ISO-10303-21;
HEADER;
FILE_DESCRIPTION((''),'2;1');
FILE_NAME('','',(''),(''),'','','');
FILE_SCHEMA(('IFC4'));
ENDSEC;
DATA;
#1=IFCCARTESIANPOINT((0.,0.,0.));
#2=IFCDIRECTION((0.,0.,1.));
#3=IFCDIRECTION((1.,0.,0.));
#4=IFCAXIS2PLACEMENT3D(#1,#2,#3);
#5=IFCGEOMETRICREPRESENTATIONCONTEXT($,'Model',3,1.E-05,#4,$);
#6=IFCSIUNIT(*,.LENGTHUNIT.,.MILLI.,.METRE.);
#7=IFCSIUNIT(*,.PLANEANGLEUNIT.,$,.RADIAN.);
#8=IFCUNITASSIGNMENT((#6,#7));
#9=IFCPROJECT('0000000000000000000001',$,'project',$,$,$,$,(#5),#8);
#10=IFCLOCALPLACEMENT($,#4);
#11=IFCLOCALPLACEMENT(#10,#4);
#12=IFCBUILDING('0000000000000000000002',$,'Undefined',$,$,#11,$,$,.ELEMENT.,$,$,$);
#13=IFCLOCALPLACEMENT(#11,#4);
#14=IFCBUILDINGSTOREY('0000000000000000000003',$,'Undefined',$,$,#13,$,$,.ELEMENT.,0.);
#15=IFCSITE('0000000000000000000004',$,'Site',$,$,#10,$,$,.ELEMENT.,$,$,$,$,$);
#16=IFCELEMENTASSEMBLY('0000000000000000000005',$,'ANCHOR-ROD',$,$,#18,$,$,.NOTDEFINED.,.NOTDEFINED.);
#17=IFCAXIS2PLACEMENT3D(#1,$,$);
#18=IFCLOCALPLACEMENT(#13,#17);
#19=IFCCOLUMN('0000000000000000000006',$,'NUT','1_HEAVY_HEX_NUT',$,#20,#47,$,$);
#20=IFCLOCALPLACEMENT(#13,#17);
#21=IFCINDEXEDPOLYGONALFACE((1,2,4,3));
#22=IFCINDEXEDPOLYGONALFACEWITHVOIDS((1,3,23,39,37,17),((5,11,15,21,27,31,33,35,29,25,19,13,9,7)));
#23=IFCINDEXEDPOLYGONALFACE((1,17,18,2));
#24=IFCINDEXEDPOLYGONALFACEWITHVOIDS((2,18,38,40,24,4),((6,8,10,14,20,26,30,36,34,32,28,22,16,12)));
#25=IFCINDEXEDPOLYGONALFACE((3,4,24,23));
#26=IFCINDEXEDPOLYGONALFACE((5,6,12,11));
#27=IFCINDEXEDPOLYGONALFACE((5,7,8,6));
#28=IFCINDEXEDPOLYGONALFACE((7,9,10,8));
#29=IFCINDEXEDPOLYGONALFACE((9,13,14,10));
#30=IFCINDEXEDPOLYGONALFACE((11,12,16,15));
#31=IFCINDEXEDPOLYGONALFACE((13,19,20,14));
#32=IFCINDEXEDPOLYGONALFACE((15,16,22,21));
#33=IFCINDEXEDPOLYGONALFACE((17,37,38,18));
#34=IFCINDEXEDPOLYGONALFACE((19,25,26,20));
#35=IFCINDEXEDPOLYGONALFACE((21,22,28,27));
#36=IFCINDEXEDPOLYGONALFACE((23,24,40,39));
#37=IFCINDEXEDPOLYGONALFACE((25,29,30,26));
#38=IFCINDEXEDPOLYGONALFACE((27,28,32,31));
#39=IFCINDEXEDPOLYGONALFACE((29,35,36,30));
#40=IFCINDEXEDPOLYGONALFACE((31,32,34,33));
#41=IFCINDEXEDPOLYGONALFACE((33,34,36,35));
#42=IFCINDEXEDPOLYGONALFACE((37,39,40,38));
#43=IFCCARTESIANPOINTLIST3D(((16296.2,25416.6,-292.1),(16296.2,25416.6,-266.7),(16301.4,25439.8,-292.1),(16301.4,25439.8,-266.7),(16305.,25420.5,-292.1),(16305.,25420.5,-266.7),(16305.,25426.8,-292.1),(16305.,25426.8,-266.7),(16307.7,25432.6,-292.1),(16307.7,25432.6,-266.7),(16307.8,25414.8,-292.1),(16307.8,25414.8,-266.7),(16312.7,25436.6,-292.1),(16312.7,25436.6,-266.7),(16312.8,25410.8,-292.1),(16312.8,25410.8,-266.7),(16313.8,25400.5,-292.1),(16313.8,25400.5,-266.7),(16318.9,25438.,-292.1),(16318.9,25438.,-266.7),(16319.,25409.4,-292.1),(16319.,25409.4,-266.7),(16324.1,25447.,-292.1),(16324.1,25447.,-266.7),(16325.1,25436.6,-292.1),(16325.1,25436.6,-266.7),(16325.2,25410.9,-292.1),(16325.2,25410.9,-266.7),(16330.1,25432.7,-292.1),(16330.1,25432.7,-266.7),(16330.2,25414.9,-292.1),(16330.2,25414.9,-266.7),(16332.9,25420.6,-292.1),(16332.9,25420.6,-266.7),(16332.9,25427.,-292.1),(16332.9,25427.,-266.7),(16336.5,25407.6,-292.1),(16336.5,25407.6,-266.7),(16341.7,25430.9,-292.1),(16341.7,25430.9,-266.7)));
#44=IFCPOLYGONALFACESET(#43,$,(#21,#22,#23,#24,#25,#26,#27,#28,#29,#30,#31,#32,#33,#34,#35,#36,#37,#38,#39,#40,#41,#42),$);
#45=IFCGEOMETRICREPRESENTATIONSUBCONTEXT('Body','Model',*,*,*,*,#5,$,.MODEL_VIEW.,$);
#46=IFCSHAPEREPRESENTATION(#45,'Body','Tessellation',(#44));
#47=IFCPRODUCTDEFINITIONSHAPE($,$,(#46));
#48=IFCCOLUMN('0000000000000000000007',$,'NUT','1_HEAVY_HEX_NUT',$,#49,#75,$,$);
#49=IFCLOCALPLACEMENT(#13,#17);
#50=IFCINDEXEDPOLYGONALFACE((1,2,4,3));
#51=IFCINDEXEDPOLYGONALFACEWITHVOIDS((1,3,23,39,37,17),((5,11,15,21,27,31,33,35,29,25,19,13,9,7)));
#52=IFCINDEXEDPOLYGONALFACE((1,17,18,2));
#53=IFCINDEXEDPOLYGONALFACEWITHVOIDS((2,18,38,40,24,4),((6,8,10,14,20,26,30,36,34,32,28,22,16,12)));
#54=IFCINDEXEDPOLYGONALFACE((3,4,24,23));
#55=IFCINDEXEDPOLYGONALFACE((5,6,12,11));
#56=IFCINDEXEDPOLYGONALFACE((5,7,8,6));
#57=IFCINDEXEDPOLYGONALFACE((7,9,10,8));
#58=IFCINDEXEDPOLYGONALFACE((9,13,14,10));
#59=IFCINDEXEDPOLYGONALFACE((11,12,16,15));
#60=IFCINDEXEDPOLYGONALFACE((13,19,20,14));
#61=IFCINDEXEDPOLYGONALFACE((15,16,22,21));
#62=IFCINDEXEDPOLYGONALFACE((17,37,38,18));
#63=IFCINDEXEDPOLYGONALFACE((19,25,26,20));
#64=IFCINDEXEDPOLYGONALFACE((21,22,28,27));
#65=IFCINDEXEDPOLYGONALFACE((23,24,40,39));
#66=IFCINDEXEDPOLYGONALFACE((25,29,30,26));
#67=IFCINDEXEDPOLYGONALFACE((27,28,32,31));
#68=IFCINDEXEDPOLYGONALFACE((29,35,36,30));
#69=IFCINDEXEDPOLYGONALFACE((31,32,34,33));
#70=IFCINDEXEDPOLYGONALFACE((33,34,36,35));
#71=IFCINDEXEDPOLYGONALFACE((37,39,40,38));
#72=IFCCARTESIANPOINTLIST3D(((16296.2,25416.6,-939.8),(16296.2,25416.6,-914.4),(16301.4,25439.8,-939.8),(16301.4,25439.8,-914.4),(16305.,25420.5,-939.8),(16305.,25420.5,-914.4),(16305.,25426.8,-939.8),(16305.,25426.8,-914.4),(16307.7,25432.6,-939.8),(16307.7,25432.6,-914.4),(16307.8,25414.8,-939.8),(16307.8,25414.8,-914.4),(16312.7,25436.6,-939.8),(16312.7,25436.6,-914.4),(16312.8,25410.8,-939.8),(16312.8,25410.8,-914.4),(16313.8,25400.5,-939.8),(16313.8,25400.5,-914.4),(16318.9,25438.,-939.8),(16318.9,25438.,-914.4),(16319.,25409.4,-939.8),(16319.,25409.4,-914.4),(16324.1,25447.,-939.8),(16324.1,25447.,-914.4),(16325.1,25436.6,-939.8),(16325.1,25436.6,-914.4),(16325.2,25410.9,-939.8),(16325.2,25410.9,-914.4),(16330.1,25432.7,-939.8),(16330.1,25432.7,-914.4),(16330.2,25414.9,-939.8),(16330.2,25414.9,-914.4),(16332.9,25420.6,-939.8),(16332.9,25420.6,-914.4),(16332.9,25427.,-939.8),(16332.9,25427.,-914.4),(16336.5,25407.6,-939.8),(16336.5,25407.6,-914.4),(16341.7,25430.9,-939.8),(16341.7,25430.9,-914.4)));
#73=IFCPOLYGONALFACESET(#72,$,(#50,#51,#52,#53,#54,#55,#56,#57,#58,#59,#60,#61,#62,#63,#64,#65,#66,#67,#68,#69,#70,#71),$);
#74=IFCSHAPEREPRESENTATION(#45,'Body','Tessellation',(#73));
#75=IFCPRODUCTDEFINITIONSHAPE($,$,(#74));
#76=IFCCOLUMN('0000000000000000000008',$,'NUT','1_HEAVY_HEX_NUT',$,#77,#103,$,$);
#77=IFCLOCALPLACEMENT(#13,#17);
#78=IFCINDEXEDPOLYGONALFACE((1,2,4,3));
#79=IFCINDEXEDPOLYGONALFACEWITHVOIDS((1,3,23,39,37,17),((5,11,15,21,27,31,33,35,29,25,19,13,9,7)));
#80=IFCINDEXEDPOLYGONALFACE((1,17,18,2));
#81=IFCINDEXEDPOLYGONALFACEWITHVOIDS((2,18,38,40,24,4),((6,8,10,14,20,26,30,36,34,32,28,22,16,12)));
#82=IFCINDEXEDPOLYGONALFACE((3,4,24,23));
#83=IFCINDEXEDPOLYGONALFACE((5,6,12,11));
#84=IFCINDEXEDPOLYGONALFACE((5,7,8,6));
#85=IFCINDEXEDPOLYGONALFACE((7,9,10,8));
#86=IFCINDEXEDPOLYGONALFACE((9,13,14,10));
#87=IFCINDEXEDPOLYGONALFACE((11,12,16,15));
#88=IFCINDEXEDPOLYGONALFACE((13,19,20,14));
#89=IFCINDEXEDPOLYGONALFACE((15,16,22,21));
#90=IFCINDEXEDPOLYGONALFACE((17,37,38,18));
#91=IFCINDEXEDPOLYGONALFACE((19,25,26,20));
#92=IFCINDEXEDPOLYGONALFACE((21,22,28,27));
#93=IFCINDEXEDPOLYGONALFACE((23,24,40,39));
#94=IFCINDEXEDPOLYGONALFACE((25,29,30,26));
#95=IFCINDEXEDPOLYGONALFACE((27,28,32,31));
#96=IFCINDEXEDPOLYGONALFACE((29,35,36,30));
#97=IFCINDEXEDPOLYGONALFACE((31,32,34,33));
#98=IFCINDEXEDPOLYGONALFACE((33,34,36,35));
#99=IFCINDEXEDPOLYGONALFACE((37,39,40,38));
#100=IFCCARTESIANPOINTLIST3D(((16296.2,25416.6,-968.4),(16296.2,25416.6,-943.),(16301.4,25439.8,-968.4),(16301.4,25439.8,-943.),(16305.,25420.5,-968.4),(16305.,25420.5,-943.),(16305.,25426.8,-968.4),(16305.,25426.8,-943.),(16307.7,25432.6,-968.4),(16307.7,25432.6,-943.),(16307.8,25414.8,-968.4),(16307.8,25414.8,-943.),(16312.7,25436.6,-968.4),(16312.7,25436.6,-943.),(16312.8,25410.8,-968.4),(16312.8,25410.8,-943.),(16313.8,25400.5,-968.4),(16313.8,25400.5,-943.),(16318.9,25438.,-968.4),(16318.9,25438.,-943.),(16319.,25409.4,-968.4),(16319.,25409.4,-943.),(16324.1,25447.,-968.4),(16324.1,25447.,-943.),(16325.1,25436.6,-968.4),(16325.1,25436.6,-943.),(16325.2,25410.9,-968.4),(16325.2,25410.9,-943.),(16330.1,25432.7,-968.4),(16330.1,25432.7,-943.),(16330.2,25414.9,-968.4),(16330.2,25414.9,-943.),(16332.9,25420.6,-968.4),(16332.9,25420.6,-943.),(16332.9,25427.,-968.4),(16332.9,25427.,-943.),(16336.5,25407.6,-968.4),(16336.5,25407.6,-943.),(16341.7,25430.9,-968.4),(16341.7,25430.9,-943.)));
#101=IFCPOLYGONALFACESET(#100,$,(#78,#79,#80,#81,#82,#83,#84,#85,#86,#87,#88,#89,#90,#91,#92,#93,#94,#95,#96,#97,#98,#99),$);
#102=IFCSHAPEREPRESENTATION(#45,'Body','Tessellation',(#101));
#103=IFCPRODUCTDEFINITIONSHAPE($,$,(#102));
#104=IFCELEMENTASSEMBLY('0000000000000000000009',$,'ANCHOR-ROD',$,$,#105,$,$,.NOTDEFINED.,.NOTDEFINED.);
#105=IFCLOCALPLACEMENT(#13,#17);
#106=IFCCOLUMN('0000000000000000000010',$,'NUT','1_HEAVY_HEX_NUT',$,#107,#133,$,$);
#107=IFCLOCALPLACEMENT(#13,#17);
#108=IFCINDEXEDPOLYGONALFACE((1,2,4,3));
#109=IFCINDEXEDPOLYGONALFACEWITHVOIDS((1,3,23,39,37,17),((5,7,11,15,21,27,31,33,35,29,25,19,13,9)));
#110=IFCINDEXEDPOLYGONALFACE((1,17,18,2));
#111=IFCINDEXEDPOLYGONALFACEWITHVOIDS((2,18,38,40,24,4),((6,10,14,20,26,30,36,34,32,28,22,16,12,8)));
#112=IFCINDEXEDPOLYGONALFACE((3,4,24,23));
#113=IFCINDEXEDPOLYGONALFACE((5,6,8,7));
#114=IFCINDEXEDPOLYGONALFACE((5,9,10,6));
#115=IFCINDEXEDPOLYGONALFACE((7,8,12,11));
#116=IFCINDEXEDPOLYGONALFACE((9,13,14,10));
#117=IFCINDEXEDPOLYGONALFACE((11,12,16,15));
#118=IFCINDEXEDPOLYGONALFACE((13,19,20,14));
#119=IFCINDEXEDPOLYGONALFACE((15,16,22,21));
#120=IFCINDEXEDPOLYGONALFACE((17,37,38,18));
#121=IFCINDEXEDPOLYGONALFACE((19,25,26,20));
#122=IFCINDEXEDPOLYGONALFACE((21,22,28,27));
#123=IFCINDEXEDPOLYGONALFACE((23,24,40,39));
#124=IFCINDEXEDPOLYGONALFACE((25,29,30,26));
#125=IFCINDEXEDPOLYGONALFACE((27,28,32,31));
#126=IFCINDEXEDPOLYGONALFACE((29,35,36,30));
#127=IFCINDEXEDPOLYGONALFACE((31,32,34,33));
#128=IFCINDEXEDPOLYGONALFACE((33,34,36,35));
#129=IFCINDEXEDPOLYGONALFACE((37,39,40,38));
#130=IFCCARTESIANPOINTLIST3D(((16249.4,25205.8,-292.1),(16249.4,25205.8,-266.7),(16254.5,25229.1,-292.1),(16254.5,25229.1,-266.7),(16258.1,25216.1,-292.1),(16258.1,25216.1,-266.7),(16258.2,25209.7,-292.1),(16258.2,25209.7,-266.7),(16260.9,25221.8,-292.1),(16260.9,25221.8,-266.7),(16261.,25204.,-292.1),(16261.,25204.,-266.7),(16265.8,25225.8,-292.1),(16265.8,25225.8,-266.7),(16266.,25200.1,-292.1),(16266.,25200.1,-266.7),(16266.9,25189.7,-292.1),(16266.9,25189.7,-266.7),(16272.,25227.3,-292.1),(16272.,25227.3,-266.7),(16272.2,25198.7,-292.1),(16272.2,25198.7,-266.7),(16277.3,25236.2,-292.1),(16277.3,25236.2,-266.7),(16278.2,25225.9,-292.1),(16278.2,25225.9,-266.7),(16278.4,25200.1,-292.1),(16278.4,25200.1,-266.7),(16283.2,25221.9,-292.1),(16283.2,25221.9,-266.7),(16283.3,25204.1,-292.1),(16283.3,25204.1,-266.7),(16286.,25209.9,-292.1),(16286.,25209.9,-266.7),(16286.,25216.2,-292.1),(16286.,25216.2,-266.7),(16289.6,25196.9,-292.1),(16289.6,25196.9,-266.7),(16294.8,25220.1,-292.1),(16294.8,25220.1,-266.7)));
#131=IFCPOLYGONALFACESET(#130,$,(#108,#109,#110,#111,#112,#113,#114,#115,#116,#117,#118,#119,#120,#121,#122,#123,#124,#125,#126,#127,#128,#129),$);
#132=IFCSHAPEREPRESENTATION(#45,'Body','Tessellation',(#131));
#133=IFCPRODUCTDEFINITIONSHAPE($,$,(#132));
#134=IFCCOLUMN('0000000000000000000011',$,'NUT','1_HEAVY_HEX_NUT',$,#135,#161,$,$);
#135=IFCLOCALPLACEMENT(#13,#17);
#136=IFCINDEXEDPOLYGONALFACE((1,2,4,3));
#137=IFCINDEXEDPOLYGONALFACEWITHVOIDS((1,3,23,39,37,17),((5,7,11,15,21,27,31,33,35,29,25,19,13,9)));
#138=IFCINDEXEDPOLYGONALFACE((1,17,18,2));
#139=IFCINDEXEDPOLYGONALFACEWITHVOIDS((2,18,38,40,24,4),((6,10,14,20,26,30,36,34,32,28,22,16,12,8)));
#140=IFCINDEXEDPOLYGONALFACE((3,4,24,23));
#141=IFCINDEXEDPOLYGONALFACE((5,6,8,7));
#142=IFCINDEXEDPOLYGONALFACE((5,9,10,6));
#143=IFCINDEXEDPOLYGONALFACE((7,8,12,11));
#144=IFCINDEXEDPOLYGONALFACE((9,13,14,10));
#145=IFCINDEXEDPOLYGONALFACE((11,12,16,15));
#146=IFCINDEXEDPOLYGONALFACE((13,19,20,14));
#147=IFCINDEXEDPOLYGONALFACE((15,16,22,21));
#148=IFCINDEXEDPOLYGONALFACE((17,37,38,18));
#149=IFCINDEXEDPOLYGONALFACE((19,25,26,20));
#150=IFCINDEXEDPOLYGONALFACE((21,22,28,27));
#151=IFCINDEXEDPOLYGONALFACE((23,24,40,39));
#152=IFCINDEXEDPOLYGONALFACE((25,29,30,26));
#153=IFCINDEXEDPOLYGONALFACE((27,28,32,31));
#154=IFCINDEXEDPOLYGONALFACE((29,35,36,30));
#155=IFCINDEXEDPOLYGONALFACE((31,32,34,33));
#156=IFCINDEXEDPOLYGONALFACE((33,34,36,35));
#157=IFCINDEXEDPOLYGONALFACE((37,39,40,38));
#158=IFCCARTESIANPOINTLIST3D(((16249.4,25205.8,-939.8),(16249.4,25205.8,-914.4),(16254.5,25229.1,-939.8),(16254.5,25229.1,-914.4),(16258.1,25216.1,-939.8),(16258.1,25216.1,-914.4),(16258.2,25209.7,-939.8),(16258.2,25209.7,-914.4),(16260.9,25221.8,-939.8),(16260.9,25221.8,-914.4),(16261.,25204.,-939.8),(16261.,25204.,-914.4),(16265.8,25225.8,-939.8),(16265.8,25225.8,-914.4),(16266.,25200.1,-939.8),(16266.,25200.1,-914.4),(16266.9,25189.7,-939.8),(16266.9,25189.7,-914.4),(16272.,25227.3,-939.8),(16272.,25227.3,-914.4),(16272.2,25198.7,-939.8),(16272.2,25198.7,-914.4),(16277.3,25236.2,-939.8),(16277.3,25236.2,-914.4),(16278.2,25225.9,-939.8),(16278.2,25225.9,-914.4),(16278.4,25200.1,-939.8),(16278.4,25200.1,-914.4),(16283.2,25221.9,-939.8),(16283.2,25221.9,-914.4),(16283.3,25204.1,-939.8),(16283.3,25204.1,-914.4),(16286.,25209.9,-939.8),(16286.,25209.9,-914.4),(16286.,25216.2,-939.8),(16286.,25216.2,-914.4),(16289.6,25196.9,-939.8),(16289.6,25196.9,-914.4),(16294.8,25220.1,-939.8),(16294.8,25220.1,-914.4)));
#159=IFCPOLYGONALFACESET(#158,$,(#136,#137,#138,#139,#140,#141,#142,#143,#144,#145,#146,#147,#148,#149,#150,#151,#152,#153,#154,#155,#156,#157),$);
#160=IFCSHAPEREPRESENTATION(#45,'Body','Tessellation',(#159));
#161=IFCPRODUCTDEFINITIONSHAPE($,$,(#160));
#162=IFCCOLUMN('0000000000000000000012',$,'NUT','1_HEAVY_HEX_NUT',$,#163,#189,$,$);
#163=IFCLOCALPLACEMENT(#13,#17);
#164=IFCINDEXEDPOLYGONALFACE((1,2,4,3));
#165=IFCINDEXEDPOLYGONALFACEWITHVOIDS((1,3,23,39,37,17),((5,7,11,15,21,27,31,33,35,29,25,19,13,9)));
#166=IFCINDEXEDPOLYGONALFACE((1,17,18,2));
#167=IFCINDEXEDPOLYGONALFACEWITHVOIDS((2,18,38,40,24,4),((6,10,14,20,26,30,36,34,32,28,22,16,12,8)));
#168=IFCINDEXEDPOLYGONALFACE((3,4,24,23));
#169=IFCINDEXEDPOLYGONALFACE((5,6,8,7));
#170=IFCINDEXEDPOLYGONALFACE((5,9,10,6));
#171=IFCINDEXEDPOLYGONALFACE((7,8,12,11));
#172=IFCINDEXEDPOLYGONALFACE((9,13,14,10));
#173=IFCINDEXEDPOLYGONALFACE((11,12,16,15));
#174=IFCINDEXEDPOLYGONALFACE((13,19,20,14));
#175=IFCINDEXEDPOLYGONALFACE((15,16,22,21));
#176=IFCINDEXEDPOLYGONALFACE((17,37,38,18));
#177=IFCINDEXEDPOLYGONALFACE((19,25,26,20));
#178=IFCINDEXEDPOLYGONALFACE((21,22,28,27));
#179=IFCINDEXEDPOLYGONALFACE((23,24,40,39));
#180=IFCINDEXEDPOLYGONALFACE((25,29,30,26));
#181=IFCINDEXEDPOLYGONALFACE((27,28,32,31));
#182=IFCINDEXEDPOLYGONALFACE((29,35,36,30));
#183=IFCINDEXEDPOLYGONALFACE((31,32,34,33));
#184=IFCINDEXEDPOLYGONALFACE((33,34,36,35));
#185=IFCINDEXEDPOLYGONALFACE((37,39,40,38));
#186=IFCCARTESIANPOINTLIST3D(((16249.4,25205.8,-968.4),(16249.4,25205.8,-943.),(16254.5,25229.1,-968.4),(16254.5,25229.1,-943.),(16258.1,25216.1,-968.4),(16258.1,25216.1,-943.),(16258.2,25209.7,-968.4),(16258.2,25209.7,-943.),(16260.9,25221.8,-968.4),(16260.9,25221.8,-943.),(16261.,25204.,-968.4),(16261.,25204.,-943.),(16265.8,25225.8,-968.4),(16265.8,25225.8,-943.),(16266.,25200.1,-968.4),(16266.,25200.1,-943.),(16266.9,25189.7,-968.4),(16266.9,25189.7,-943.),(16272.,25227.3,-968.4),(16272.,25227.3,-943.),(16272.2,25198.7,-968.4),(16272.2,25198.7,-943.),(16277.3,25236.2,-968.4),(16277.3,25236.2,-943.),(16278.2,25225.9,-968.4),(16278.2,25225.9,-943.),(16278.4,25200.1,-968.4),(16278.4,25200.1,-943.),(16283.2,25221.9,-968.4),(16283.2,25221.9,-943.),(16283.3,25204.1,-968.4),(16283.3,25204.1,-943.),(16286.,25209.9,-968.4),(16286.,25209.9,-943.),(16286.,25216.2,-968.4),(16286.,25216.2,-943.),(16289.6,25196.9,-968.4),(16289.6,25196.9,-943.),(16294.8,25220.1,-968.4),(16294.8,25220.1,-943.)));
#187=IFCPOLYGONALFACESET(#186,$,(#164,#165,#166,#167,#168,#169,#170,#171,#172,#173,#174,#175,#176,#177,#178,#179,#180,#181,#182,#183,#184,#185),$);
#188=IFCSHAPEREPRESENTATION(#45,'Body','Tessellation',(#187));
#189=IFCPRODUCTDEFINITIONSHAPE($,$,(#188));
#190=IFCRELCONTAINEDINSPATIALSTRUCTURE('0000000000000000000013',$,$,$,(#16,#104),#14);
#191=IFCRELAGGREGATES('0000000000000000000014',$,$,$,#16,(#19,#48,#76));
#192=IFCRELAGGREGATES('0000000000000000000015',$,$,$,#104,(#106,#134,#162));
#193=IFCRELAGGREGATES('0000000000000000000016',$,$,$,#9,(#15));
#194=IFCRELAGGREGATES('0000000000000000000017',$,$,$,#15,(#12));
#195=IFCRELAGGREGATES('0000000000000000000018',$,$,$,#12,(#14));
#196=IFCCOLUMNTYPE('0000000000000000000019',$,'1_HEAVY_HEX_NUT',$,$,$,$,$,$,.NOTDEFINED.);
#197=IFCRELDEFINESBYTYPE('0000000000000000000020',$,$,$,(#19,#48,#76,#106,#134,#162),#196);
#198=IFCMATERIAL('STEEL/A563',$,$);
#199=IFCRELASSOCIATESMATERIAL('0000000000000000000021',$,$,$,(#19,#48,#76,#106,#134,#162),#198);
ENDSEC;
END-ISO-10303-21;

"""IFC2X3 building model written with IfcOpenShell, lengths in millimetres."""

from ifc_helpers import new_model, si_unit, frame, origin_with_axes, place, context, subcontext, project, spatial, polyline, outline, extrude, material, type_object, element, aggregate, save


model = new_model("IFC2X3")

# Units and contexts
model_context = context("Model", 3, precision=1e-05, world=origin_with_axes())
body_context = subcontext(model_context, "Body", "Model", "MODEL_VIEW")
ifc_project = project(units=[si_unit("LENGTHUNIT", "METRE", prefix="MILLI"), si_unit("PLANEANGLEUNIT", "RADIAN")], contexts=[model_context])

# Site, building, storey
site_placement = place(None, origin_with_axes())
site = spatial("IfcSite", under=ifc_project, at=site_placement, Name="Site", CompositionType="ELEMENT")
building_placement = place(site_placement, origin_with_axes())
building = spatial("IfcBuilding", under=site, at=building_placement, Name="Undefined", CompositionType="ELEMENT")
storey_placement = place(building_placement, origin_with_axes())
storey = spatial("IfcBuildingStorey", under=building, at=storey_placement, Name="Undefined", CompositionType="ELEMENT", Elevation=0.0)

# Element assemblies, columns
ifc_material_1 = material(Name="STEEL/A563")
column_type_1 = type_object("IfcColumnType", Name="1_HEAVY_HEX_NUT", PredefinedType="NOTDEFINED")
assembly_1_placement = place(storey_placement, origin_with_axes())
assembly_1 = element("IfcElementAssembly", 1, at=assembly_1_placement, inside=storey, Name="ANCHOR-ROD", AssemblyPlace="NOTDEFINED", PredefinedType="NOTDEFINED")
column_1_placement = place(assembly_1_placement, frame((16318.9, 25423.7, -266.7), z_axis=(0.0, 0.0, -1.0), x_axis=(-0.976162, 0.217044, 0.0)))
column_1 = element("IfcColumn", 2, at=column_1_placement, type_object=column_type_1, material=ifc_material_1, Name="NUT", Description="1_HEAVY_HEX_NUT", context=body_context, shape_type="SweptSolid", body=[
    extrude(outline(polyline([(-11.9, -20.6), (-23.8, 0.0), (-11.9, 20.6), (11.9, 20.6), (23.8, 0.0), (11.9, -20.6), (-11.9, -20.6)]), holes=[polyline([(11.2, 8.9), (6.2, 12.9), (0.0, 14.3), (-6.2, 12.9), (-11.2, 8.9), (-13.9, 3.2), (-13.9, -3.2), (-11.2, -8.9), (-6.2, -12.9), (0.0, -14.3), (6.2, -12.9), (11.2, -8.9), (13.9, -3.2), (13.9, 3.2), (11.2, 8.9)])]), frame((0.0, 0.0, 25.4), z_axis=(0.0, 0.0, -1.0), x_axis=(0.0, 1.0, 0.0)), (0.0, 0.0, 1.0), 25.4),
])
column_2_placement = place(assembly_1_placement, frame((16318.9, 25423.7, -914.4), z_axis=(0.0, 0.0, -1.0), x_axis=(-0.976162, 0.217044, 0.0)))
column_2 = element("IfcColumn", 3, at=column_2_placement, type_object=column_type_1, material=ifc_material_1, Name="NUT", Description="1_HEAVY_HEX_NUT", context=body_context, shape_type="SweptSolid", body=[
    extrude(outline(polyline([(-11.9, -20.6), (-23.8, 0.0), (-11.9, 20.6), (11.9, 20.6), (23.8, 0.0), (11.9, -20.6), (-11.9, -20.6)]), holes=[polyline([(11.2, 8.9), (6.2, 12.9), (0.0, 14.3), (-6.2, 12.9), (-11.2, 8.9), (-13.9, 3.2), (-13.9, -3.2), (-11.2, -8.9), (-6.2, -12.9), (0.0, -14.3), (6.2, -12.9), (11.2, -8.9), (13.9, -3.2), (13.9, 3.2), (11.2, 8.9)])]), frame((0.0, 0.0, 25.4), z_axis=(0.0, 0.0, -1.0), x_axis=(0.0, 1.0, 0.0)), (0.0, 0.0, 1.0), 25.4),
])
column_3_placement = place(assembly_1_placement, frame((16318.9, 25423.7, -943.0), z_axis=(0.0, 0.0, -1.0), x_axis=(-0.976162, 0.217044, 0.0)))
column_3 = element("IfcColumn", 4, at=column_3_placement, type_object=column_type_1, material=ifc_material_1, Name="NUT", Description="1_HEAVY_HEX_NUT", context=body_context, shape_type="SweptSolid", body=[
    extrude(outline(polyline([(-11.9, -20.6), (-23.8, 0.0), (-11.9, 20.6), (11.9, 20.6), (23.8, 0.0), (11.9, -20.6), (-11.9, -20.6)]), holes=[polyline([(11.2, 8.9), (6.2, 12.9), (0.0, 14.3), (-6.2, 12.9), (-11.2, 8.9), (-13.9, 3.2), (-13.9, -3.2), (-11.2, -8.9), (-6.2, -12.9), (0.0, -14.3), (6.2, -12.9), (11.2, -8.9), (13.9, -3.2), (13.9, 3.2), (11.2, 8.9)])]), frame((0.0, 0.0, 25.4), z_axis=(0.0, 0.0, -1.0), x_axis=(0.0, 1.0, 0.0)), (0.0, 0.0, 1.0), 25.4),
])
assembly_2_placement = place(storey_placement, origin_with_axes())
assembly_2 = element("IfcElementAssembly", 5, at=assembly_2_placement, inside=storey, Name="ANCHOR-ROD", AssemblyPlace="NOTDEFINED", PredefinedType="NOTDEFINED")
column_4_placement = place(assembly_2_placement, frame((16272.1, 25213.0, -266.7), z_axis=(0.0, 0.0, -1.0), x_axis=(0.976162, -0.217044, 0.0)))
column_4 = element("IfcColumn", 6, at=column_4_placement, type_object=column_type_1, material=ifc_material_1, Name="NUT", Description="1_HEAVY_HEX_NUT", context=body_context, shape_type="SweptSolid", body=[
    extrude(outline(polyline([(-11.9, -20.6), (-23.8, 0.0), (-11.9, 20.6), (11.9, 20.6), (23.8, 0.0), (11.9, -20.6), (-11.9, -20.6)]), holes=[polyline([(11.2, 8.9), (6.2, 12.9), (0.0, 14.3), (-6.2, 12.9), (-11.2, 8.9), (-13.9, 3.2), (-13.9, -3.2), (-11.2, -8.9), (-6.2, -12.9), (0.0, -14.3), (6.2, -12.9), (11.2, -8.9), (13.9, -3.2), (13.9, 3.2), (11.2, 8.9)])]), frame((0.0, 0.0, 25.4), z_axis=(0.0, 0.0, -1.0), x_axis=(0.0, 1.0, 0.0)), (0.0, 0.0, 1.0), 25.4),
])
column_5_placement = place(assembly_2_placement, frame((16272.1, 25213.0, -914.4), z_axis=(0.0, 0.0, -1.0), x_axis=(0.976162, -0.217044, 0.0)))
column_5 = element("IfcColumn", 7, at=column_5_placement, type_object=column_type_1, material=ifc_material_1, Name="NUT", Description="1_HEAVY_HEX_NUT", context=body_context, shape_type="SweptSolid", body=[
    extrude(outline(polyline([(-11.9, -20.6), (-23.8, 0.0), (-11.9, 20.6), (11.9, 20.6), (23.8, 0.0), (11.9, -20.6), (-11.9, -20.6)]), holes=[polyline([(11.2, 8.9), (6.2, 12.9), (0.0, 14.3), (-6.2, 12.9), (-11.2, 8.9), (-13.9, 3.2), (-13.9, -3.2), (-11.2, -8.9), (-6.2, -12.9), (0.0, -14.3), (6.2, -12.9), (11.2, -8.9), (13.9, -3.2), (13.9, 3.2), (11.2, 8.9)])]), frame((0.0, 0.0, 25.4), z_axis=(0.0, 0.0, -1.0), x_axis=(0.0, 1.0, 0.0)), (0.0, 0.0, 1.0), 25.4),
])
column_6_placement = place(assembly_2_placement, frame((16272.1, 25213.0, -943.0), z_axis=(0.0, 0.0, -1.0), x_axis=(0.976162, -0.217044, 0.0)))
column_6 = element("IfcColumn", 8, at=column_6_placement, type_object=column_type_1, material=ifc_material_1, Name="NUT", Description="1_HEAVY_HEX_NUT", context=body_context, shape_type="SweptSolid", body=[
    extrude(outline(polyline([(-11.9, -20.6), (-23.8, 0.0), (-11.9, 20.6), (11.9, 20.6), (23.8, 0.0), (11.9, -20.6), (-11.9, -20.6)]), holes=[polyline([(11.2, 8.9), (6.2, 12.9), (0.0, 14.3), (-6.2, 12.9), (-11.2, 8.9), (-13.9, 3.2), (-13.9, -3.2), (-11.2, -8.9), (-6.2, -12.9), (0.0, -14.3), (6.2, -12.9), (11.2, -8.9), (13.9, -3.2), (13.9, 3.2), (11.2, 8.9)])]), frame((0.0, 0.0, 25.4), z_axis=(0.0, 0.0, -1.0), x_axis=(0.0, 1.0, 0.0)), (0.0, 0.0, 1.0), 25.4),
])

aggregate(assembly_1, [column_1, column_2, column_3])
aggregate(assembly_2, [column_4, column_5, column_6])

save(model, "model.ifc")
